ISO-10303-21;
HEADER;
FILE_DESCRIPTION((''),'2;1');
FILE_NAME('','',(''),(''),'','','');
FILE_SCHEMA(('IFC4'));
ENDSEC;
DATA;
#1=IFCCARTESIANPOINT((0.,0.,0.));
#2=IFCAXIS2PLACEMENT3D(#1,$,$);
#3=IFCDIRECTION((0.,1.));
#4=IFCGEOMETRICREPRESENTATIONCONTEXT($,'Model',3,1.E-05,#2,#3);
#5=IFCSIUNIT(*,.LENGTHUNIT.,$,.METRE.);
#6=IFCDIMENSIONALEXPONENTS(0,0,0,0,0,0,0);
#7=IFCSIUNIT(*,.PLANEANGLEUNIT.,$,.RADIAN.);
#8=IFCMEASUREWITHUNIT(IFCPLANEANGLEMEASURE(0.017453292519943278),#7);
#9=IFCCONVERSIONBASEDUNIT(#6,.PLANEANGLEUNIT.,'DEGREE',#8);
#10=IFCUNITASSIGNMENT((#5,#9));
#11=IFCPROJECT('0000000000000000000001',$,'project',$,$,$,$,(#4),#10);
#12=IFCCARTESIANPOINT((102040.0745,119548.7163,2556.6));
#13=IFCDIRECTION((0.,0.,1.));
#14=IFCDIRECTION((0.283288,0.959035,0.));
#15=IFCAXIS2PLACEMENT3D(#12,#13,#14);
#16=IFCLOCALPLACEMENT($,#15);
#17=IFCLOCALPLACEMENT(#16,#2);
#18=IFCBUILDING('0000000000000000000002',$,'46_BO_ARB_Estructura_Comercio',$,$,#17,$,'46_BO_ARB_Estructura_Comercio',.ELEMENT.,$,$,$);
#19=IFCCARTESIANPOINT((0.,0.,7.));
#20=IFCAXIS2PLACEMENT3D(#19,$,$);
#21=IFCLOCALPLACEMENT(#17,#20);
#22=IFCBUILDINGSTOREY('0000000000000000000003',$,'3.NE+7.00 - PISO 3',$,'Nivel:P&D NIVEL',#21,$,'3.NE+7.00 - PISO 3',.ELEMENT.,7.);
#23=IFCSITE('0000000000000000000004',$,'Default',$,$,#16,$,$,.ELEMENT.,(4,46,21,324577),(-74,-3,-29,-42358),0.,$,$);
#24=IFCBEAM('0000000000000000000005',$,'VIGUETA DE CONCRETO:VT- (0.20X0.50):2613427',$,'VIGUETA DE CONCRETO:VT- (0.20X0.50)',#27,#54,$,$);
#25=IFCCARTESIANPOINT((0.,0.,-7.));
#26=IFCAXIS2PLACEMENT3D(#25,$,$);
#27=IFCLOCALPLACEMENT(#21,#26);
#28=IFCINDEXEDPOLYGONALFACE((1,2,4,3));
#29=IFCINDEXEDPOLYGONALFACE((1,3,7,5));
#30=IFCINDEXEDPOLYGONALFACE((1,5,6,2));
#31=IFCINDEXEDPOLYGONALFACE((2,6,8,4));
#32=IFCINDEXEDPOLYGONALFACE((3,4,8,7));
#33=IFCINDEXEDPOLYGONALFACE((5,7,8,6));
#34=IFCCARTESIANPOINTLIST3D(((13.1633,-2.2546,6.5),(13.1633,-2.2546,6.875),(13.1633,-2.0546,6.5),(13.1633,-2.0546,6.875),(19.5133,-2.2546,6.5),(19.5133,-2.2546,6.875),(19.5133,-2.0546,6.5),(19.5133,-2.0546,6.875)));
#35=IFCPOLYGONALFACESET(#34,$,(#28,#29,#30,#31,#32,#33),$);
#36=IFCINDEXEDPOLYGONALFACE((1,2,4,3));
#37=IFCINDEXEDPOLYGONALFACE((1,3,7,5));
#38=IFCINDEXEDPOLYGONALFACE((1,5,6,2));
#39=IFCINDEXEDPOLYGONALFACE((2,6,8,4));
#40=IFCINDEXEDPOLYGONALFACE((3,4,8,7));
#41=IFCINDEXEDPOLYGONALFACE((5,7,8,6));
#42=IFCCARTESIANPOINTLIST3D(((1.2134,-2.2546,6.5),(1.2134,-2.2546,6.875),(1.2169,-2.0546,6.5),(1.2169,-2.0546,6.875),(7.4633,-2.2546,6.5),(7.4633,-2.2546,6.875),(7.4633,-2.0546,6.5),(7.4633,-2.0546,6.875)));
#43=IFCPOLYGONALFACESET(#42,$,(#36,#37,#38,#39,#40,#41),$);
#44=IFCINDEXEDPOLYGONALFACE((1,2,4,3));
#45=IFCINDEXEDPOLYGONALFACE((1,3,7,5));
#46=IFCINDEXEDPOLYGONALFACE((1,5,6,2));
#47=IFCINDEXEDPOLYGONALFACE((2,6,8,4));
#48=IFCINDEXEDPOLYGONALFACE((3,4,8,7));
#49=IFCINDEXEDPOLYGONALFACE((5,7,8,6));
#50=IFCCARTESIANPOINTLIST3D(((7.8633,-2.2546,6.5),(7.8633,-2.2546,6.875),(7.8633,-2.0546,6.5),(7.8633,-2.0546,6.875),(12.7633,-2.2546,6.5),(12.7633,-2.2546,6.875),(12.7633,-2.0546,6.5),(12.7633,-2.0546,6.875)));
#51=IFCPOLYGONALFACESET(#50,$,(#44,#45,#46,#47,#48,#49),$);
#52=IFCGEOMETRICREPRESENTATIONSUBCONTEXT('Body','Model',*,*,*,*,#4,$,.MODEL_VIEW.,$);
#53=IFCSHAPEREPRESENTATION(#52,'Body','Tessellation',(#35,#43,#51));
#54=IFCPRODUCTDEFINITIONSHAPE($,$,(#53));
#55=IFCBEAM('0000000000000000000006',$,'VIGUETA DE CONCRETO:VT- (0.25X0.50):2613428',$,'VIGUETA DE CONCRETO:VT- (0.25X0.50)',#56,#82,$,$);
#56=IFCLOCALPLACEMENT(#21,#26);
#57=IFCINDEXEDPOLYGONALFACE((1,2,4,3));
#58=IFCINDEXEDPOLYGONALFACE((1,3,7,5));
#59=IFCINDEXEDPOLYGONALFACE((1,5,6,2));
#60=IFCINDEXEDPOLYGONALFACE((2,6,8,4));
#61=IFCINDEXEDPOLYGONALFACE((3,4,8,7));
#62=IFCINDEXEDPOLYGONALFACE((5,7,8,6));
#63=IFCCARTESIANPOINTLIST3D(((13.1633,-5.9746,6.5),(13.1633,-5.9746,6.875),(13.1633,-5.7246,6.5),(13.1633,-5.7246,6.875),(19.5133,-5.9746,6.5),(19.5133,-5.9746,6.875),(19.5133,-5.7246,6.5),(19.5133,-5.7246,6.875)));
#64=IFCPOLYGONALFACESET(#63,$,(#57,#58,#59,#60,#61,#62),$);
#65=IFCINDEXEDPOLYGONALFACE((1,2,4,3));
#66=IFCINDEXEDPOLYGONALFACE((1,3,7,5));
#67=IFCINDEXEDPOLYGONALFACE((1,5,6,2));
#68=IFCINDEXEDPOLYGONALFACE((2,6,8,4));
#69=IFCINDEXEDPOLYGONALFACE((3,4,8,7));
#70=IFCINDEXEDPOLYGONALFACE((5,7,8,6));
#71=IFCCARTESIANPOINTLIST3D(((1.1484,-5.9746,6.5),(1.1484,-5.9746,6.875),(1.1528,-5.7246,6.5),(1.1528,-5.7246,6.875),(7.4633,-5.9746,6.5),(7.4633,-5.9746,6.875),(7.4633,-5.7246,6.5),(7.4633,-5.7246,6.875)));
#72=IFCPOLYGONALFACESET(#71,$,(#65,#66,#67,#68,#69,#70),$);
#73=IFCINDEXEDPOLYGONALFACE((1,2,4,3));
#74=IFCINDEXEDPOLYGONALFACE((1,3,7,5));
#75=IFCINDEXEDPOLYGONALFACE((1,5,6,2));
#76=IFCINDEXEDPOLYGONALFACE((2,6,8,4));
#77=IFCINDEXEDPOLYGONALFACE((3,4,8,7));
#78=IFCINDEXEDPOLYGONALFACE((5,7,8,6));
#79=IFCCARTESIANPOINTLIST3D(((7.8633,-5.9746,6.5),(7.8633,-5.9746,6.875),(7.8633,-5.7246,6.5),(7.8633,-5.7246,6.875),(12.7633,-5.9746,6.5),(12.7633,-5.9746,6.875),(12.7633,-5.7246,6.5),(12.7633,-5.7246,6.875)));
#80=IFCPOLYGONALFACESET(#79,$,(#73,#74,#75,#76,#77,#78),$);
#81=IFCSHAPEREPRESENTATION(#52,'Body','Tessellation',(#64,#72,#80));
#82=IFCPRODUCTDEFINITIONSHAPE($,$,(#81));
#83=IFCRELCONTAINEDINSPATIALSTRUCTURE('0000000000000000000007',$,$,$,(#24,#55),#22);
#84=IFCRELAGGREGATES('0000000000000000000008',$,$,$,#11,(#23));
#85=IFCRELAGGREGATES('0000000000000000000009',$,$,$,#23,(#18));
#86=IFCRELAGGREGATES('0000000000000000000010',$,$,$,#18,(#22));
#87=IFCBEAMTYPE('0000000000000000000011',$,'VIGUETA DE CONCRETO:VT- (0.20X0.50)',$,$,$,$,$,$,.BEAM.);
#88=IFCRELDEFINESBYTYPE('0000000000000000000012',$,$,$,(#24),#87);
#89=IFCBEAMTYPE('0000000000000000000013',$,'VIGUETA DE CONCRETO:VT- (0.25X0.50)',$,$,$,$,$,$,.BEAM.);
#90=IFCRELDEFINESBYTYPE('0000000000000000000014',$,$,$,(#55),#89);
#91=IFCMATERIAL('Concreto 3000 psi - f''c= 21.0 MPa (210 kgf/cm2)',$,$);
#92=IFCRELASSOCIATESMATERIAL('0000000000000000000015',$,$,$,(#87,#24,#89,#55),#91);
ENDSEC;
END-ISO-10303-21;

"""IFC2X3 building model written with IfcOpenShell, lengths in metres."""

from ifc_helpers import new_model, entity, si_unit, converted_unit, direction, frame, frame_2d, origin, place, context, subcontext, project, spatial, rectangle, extrude, clip, halfspace, source, transform, mapped, material, type_object, type_shapes, element, save


model = new_model("IFC2X3")

# Units and contexts
model_context = context("Model", 3, precision=1e-05, world=origin(), true_north=direction((0.0, 1.0)))
body_context = subcontext(model_context, "Body", "Model", "MODEL_VIEW")
ifc_project = project(units=[si_unit("LENGTHUNIT", "METRE"), converted_unit("PLANEANGLEUNIT", "DEGREE", entity("IfcPlaneAngleMeasure", 0.017453292519943278), si_unit("PLANEANGLEUNIT", "RADIAN"), dimensions=[0, 0, 0, 0, 0, 0, 0])], contexts=[model_context])

# Site, building, storey
site_placement = place(None, frame((102040.0745, 119548.7163, 2556.6), z_axis=(0.0, 0.0, 1.0), x_axis=(0.283288, 0.959035, 0.0)))
site = spatial("IfcSite", under=ifc_project, at=site_placement, Name="Default", CompositionType="ELEMENT", RefLatitude=(4, 46, 21, 324577), RefLongitude=(-74, -3, -29, -42358), RefElevation=0.0)
building_placement = place(site_placement, origin())
building = spatial("IfcBuilding", under=site, at=building_placement, Name="46_BO_ARB_Estructura_Comercio", LongName="46_BO_ARB_Estructura_Comercio", CompositionType="ELEMENT")
storey_placement = place(building_placement, frame((0.0, 0.0, 7.0)))
storey = spatial("IfcBuildingStorey", under=building, at=storey_placement, Name="3.NE+7.00 - PISO 3", ObjectType="Nivel:P&D NIVEL", LongName="3.NE+7.00 - PISO 3", CompositionType="ELEMENT", Elevation=7.0)

# Beams
ifc_material = material(Name="Concreto 3000 psi - f'c= 21.0 MPa (210 kgf/cm2)")
beam_type_1 = type_object("IfcBeamType", Name="VIGUETA DE CONCRETO:VT- (0.20X0.50)", PredefinedType="BEAM", material=ifc_material)
shared_shape_1 = source(origin(), body_context, "Body", "SweptSolid", [
    extrude(rectangle(XDim=0.375, YDim=0.2, at=frame_2d((0.0, 0.0), x_axis=(1.0, 0.0))), frame((13.1633, -2.1546, 6.6875), z_axis=(1.0, 0.0, 0.0), x_axis=(0.0, 0.0, -1.0)), (0.0, 0.0, 1.0), 6.35),
    clip(extrude(rectangle(XDim=0.375, YDim=0.2, at=frame_2d((0.0, 0.0), x_axis=(1.0, 0.0))), frame((1.2134, -2.1546, 6.6875), z_axis=(1.0, 0.0, 0.0), x_axis=(0.0, 0.0, -1.0)), (0.0, 0.0, 1.0), 6.2499), halfspace(frame((1.2357, -0.9774, 7.0), z_axis=(-0.999847, 0.017477, 0.0), x_axis=(-0.017477, -0.999847, 0.0)), False)),
    extrude(rectangle(XDim=0.375, YDim=0.2, at=frame_2d((0.0, 0.0), x_axis=(1.0, 0.0))), frame((7.8633, -2.1546, 6.6875), z_axis=(1.0, 0.0, 0.0), x_axis=(0.0, 0.0, -1.0)), (0.0, 0.0, 1.0), 4.9),
])
type_shapes(beam_type_1, [shared_shape_1])
beam_1_placement = place(storey_placement, frame((0.0, 0.0, -7.0)))
element("IfcBeam", 1, at=beam_1_placement, inside=storey, type_object=beam_type_1, material=ifc_material, Name="VIGUETA DE CONCRETO:VT- (0.20X0.50):2613427", ObjectType="VIGUETA DE CONCRETO:VT- (0.20X0.50)", context=body_context, shape_type="MappedRepresentation", body=[
    mapped(shared_shape_1, transform((0.0, 0.0, 0.0), scale=1.0)),
])
beam_type_2 = type_object("IfcBeamType", Name="VIGUETA DE CONCRETO:VT- (0.25X0.50)", PredefinedType="BEAM", material=ifc_material)
shared_shape_2 = source(origin(), body_context, "Body", "SweptSolid", [
    extrude(rectangle(XDim=0.375, YDim=0.25, at=frame_2d((0.0, 0.0), x_axis=(1.0, 0.0))), frame((13.1633, -5.8496, 6.6875), z_axis=(1.0, 0.0, 0.0), x_axis=(0.0, 0.0, -1.0)), (0.0, 0.0, 1.0), 6.35),
    clip(extrude(rectangle(XDim=0.375, YDim=0.25, at=frame_2d((0.0, 0.0), x_axis=(1.0, 0.0))), frame((1.1484, -5.8496, 6.6875), z_axis=(1.0, 0.0, 0.0), x_axis=(0.0, 0.0, -1.0)), (0.0, 0.0, 1.0), 6.3149), halfspace(frame((1.2357, -0.9774, 7.0), z_axis=(-0.999847, 0.017477, 0.0), x_axis=(-0.017477, -0.999847, 0.0)), False)),
    extrude(rectangle(XDim=0.375, YDim=0.25, at=frame_2d((0.0, 0.0), x_axis=(1.0, 0.0))), frame((7.8633, -5.8496, 6.6875), z_axis=(1.0, 0.0, 0.0), x_axis=(0.0, 0.0, -1.0)), (0.0, 0.0, 1.0), 4.9),
])
type_shapes(beam_type_2, [shared_shape_2])
beam_2_placement = place(storey_placement, frame((0.0, 0.0, -7.0)))
element("IfcBeam", 2, at=beam_2_placement, inside=storey, type_object=beam_type_2, material=ifc_material, Name="VIGUETA DE CONCRETO:VT- (0.25X0.50):2613428", ObjectType="VIGUETA DE CONCRETO:VT- (0.25X0.50)", context=body_context, shape_type="MappedRepresentation", body=[
    mapped(shared_shape_2, transform((0.0, 0.0, 0.0), scale=1.0)),
])

save(model, "model.ifc")
